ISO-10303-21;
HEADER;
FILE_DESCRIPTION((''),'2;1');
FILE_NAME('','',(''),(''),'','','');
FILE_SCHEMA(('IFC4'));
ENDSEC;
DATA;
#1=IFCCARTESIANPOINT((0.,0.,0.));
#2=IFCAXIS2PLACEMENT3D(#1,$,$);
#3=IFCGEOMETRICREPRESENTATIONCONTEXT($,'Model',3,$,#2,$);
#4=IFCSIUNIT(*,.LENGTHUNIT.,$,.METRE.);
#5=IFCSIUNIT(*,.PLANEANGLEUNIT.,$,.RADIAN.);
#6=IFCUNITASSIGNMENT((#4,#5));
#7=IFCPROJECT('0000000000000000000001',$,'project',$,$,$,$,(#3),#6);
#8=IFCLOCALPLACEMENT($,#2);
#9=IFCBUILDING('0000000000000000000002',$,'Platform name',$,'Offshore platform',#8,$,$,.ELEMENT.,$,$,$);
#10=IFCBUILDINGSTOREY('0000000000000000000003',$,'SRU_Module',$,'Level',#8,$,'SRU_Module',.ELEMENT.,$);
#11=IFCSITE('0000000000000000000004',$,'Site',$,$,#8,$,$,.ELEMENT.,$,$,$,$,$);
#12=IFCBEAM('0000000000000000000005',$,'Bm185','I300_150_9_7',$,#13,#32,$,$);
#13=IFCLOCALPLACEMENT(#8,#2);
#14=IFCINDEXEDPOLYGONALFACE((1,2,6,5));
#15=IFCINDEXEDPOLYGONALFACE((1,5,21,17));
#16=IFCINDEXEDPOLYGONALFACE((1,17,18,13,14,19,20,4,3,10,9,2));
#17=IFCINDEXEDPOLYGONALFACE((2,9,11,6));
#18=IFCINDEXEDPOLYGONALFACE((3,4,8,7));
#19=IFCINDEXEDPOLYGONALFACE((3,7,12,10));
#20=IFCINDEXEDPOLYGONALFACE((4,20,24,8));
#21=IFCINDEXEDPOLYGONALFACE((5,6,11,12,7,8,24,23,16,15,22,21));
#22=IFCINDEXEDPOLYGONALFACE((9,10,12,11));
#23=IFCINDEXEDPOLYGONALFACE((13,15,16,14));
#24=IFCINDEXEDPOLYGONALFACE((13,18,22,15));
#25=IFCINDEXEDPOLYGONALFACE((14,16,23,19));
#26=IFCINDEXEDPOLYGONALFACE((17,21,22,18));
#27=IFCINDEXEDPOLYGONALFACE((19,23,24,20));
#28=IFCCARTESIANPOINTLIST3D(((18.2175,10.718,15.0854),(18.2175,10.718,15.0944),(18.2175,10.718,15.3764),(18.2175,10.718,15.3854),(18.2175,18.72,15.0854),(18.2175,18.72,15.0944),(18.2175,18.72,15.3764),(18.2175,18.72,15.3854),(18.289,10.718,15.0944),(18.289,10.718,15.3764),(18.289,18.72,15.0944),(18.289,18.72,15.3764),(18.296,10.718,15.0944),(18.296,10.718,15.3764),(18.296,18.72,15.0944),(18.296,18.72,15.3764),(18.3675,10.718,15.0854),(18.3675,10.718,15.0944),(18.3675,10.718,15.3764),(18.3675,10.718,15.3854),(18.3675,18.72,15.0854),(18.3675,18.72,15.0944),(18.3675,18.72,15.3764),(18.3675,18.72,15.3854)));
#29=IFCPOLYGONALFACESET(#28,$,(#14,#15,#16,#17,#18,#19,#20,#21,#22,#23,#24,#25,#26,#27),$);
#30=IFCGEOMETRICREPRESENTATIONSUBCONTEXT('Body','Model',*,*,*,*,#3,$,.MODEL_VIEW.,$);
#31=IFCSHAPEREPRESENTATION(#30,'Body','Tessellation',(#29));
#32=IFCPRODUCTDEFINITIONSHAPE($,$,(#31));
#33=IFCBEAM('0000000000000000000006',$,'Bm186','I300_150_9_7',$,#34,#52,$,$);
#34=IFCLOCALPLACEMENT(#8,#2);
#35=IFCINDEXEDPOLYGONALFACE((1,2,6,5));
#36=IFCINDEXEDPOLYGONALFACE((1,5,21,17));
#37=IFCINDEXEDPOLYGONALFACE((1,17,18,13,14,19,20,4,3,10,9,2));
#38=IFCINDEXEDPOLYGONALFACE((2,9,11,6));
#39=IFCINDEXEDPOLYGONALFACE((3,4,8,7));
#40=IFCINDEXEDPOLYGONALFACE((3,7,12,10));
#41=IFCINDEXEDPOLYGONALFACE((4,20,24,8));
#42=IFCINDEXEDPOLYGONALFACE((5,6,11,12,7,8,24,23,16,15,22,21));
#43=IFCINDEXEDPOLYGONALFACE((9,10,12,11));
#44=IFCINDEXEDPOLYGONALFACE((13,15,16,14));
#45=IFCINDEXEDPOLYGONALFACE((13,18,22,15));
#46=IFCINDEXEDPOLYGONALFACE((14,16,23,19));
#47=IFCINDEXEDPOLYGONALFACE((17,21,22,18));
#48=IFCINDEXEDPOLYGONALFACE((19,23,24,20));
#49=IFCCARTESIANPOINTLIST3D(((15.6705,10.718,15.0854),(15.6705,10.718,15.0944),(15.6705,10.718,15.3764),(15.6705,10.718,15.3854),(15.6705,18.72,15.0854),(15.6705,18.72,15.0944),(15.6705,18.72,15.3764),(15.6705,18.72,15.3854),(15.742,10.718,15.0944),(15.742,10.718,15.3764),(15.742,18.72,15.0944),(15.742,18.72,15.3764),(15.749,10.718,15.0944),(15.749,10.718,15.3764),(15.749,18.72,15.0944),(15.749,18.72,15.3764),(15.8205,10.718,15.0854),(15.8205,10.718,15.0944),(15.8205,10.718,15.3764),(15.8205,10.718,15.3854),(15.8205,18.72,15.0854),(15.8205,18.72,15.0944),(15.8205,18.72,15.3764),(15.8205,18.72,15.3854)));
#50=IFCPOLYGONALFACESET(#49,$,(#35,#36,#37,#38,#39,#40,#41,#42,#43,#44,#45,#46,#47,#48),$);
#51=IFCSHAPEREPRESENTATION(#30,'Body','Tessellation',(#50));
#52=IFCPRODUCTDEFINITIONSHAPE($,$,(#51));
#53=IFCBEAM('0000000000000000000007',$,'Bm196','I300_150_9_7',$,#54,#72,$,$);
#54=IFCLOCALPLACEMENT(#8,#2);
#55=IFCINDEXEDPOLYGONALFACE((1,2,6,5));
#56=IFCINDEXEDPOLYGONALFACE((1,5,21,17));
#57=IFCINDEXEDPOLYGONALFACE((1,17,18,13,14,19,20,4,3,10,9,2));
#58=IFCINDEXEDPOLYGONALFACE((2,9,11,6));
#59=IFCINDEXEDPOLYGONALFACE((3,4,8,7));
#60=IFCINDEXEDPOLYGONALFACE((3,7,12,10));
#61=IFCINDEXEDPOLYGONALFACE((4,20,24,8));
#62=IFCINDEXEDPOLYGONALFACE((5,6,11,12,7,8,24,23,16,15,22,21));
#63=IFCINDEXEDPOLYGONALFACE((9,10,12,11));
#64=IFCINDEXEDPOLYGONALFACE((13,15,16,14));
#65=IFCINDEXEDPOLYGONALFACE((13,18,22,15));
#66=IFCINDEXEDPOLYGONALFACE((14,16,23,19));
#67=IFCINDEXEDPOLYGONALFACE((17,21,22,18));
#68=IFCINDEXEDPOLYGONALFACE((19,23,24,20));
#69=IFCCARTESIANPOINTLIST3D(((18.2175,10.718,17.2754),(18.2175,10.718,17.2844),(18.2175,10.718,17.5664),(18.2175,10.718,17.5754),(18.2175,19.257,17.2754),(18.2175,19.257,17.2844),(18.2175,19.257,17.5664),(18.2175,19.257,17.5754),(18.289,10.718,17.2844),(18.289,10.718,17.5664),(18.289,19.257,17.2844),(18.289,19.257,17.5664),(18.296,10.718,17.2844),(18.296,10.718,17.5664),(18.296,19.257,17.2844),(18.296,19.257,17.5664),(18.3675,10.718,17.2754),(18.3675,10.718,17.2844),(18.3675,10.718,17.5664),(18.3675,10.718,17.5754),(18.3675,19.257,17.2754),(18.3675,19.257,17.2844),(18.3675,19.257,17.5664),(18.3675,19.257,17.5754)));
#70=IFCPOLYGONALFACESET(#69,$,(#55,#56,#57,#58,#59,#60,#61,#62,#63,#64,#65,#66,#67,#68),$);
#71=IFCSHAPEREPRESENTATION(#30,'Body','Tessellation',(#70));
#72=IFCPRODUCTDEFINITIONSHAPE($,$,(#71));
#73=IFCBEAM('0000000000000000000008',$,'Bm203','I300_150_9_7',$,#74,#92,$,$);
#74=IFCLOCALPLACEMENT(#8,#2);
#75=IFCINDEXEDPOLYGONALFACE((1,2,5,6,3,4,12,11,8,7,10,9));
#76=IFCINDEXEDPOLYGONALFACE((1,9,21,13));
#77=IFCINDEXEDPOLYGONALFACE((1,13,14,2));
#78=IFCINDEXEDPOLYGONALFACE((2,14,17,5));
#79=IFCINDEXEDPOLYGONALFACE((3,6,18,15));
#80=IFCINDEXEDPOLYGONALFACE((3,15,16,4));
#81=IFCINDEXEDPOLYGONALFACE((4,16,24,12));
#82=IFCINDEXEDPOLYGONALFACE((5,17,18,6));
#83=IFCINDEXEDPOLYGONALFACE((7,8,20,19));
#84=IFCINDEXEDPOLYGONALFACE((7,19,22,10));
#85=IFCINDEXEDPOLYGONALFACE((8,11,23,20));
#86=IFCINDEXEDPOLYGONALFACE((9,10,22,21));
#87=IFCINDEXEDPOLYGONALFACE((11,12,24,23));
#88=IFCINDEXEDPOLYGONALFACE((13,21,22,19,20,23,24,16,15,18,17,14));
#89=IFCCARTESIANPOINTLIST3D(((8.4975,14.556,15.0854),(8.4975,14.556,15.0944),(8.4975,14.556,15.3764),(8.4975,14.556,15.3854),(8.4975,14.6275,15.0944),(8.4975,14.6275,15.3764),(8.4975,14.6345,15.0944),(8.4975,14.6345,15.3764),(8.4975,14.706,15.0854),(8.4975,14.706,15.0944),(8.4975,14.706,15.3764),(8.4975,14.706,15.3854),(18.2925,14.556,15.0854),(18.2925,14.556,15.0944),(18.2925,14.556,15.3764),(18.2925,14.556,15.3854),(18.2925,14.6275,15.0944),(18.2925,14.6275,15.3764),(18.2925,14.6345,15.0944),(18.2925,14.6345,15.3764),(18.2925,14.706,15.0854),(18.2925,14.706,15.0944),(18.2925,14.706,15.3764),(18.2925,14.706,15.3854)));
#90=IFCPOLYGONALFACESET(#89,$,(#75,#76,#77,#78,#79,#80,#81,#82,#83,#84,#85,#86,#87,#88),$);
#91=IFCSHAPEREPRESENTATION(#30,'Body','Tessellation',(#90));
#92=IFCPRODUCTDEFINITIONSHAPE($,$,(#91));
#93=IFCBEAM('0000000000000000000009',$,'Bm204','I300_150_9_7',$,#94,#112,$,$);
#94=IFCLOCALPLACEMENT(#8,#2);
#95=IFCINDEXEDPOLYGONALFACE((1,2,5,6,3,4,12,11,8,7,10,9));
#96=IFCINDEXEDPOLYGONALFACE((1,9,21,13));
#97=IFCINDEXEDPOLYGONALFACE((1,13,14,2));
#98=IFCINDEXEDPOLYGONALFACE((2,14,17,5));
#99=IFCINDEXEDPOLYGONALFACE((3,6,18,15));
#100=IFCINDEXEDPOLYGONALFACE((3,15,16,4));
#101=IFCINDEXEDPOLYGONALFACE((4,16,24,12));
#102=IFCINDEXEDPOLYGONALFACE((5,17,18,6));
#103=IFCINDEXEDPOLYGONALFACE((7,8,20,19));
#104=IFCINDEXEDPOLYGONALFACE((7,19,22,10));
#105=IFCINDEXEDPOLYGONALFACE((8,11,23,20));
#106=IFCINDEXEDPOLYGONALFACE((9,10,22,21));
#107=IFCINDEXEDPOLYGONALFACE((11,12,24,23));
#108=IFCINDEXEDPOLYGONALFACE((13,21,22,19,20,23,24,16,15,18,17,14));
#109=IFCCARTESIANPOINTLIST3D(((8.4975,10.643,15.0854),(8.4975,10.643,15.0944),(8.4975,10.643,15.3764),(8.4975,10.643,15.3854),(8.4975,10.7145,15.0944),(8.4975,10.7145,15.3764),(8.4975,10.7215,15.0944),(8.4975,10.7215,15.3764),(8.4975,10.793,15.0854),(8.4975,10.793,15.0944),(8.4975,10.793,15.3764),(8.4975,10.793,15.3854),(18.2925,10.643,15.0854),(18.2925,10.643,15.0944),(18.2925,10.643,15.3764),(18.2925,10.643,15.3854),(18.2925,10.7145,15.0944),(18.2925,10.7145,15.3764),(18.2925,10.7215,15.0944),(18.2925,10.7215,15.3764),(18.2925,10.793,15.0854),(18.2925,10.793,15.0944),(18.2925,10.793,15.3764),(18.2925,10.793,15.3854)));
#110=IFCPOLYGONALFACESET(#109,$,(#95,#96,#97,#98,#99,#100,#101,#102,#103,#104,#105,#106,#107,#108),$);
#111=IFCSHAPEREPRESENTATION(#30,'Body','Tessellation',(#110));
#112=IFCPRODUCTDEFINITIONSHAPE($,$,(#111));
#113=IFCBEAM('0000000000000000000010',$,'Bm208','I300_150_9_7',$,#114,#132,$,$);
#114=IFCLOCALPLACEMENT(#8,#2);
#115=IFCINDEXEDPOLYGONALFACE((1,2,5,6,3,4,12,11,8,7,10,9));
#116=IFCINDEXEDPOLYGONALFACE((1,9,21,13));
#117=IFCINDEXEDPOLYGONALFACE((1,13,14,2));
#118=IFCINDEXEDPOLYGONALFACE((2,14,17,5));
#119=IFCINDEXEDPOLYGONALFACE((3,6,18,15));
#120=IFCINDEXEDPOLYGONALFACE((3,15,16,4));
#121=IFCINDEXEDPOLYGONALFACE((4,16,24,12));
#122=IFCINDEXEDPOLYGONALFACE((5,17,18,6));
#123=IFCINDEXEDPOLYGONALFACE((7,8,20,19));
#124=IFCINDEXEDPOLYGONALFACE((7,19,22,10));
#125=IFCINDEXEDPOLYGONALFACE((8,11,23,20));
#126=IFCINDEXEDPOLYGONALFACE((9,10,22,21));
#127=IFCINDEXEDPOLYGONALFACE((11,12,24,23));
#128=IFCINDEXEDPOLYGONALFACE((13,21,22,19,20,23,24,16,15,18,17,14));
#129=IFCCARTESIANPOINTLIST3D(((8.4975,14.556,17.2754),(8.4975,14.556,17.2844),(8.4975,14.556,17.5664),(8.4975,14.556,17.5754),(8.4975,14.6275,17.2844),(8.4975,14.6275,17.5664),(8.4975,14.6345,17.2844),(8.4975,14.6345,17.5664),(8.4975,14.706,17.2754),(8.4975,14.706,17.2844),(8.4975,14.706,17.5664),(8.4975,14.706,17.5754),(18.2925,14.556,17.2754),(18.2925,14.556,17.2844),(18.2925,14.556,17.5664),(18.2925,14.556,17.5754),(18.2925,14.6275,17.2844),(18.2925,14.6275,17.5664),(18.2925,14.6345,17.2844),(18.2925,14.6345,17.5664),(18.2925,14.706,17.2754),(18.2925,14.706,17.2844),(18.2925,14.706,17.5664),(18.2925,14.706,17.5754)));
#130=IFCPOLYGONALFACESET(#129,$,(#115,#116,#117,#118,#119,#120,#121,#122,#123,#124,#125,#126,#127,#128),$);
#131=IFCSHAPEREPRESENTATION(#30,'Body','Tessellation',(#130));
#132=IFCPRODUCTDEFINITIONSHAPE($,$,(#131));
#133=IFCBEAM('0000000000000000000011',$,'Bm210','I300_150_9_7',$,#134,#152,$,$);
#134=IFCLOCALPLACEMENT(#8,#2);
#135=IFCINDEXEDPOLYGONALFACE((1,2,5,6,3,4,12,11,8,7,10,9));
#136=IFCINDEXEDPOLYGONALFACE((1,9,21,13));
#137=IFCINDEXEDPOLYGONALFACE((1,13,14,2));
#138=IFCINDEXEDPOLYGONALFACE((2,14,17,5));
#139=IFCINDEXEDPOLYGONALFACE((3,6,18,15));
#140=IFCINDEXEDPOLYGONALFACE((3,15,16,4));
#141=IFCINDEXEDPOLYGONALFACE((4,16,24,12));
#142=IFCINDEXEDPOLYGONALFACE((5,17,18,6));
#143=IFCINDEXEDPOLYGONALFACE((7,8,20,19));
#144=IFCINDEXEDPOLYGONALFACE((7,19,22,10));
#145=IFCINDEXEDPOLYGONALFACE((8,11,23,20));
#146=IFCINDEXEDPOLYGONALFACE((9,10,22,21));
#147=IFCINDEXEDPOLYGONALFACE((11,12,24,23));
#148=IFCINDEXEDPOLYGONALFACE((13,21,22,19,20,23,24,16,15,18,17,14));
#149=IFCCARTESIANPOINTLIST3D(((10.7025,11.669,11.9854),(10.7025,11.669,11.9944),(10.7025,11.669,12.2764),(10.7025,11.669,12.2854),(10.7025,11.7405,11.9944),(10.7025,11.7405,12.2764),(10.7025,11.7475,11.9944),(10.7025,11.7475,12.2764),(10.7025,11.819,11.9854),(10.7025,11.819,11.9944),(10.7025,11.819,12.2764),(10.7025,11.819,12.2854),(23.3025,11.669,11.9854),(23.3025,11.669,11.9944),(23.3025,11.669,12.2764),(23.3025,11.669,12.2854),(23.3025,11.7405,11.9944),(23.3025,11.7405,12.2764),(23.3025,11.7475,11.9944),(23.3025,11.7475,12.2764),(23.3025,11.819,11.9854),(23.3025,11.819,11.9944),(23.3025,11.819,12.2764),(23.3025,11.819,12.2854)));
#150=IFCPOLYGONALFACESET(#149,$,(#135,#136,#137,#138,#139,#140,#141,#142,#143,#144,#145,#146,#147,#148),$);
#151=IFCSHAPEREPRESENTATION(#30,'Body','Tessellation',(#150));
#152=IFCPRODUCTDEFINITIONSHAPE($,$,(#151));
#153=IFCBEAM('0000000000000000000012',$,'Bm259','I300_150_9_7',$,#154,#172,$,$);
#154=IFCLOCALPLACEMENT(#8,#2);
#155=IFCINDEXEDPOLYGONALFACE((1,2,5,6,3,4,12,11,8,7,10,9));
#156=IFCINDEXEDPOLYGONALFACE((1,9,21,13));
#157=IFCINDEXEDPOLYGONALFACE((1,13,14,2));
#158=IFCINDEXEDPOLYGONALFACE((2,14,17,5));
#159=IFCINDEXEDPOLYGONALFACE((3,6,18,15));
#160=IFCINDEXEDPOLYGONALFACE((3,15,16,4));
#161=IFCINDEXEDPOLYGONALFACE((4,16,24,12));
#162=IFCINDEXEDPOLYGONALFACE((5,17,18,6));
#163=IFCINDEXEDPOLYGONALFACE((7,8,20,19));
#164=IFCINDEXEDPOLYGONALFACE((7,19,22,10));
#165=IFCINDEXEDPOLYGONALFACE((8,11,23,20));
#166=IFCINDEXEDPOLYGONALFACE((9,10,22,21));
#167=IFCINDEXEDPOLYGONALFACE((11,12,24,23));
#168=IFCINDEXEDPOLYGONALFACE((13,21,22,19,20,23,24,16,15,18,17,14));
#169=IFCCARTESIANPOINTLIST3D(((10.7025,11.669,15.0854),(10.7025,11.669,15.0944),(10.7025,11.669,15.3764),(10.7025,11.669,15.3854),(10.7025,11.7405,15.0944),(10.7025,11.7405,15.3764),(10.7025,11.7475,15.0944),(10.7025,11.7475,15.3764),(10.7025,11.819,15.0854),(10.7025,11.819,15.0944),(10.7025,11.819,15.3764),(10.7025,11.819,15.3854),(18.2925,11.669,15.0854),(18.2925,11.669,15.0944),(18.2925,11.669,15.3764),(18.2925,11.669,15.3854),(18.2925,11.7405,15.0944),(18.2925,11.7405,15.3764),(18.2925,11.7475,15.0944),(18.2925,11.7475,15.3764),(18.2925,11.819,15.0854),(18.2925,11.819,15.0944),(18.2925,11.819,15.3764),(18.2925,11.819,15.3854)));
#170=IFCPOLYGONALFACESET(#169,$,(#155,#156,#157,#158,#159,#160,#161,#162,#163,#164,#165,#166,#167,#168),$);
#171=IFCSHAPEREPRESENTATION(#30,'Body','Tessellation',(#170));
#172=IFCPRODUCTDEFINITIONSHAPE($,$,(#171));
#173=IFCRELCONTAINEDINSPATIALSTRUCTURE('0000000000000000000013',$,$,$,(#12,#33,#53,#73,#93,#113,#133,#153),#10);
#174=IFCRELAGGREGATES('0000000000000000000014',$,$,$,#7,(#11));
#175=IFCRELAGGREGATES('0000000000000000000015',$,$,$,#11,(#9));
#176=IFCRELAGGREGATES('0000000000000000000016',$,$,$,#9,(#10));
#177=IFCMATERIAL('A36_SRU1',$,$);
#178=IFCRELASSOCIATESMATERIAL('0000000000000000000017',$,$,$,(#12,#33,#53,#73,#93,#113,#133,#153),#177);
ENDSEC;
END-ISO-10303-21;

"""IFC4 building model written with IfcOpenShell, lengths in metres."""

from ifc_helpers import new_model, si_unit, frame, origin, origin_2d, place, context, subcontext, project, spatial, i_section, extrude, source, transform, mapped, material, element, save


model = new_model("IFC4")

# Units and contexts
model_context = context("Model", 3, world=origin())
body_context = subcontext(model_context, "Body", "Model", "MODEL_VIEW")
ifc_project = project(units=[si_unit("LENGTHUNIT", "METRE"), si_unit("PLANEANGLEUNIT", "RADIAN")], contexts=[model_context])

# Site, building, storey
placement_1 = place(None, origin())
site = spatial("IfcSite", under=ifc_project, at=placement_1, Name="Site", CompositionType="ELEMENT")
building = spatial("IfcBuilding", under=site, at=placement_1, Name="Platform name", ObjectType="Offshore platform", CompositionType="ELEMENT")
storey = spatial("IfcBuildingStorey", under=building, at=placement_1, Name="SRU_Module", ObjectType="Level", LongName="SRU_Module", CompositionType="ELEMENT")

# Beams
ifc_material = material(Name="A36_SRU1")
shared_shape_1 = source(origin(), body_context, "Body", "SweptSolid", [
    extrude(i_section(OverallWidth=0.15, OverallDepth=0.3, WebThickness=0.007, FlangeThickness=0.009, FilletRadius=0.0, at=origin_2d()), frame((0.0, 0.0, 0.0), z_axis=(0.0, 1.0, 0.0), x_axis=(-1.0, 0.0, 0.0)), (0.0, 0.0, 1.0), 8.002),
])
placement_2 = place(None, origin())
placement_3 = place(placement_2, origin())
placement_4 = place(placement_3, origin())
beam_1_placement = place(placement_4, frame((18.2925, 10.718, 15.2354)))
element("IfcBeam", 1, at=beam_1_placement, inside=storey, material=ifc_material, Name="Bm185", Description="I300_150_9_7", context=body_context, shape_type="MappedRepresentation", body=[
    mapped(shared_shape_1, transform((0.0, 0.0, 0.0), scale=1.0)),
])
shared_shape_2 = source(origin(), body_context, "Body", "SweptSolid", [
    extrude(i_section(OverallWidth=0.15, OverallDepth=0.3, WebThickness=0.007, FlangeThickness=0.009, FilletRadius=0.0, at=origin_2d()), frame((0.0, 0.0, 0.0), z_axis=(0.0, 1.0, 0.0), x_axis=(-1.0, 0.0, 0.0)), (0.0, 0.0, 1.0), 8.002),
])
placement_5 = place(None, origin())
placement_6 = place(placement_5, origin())
placement_7 = place(placement_6, origin())
beam_2_placement = place(placement_7, frame((15.7455, 10.718, 15.2354)))
element("IfcBeam", 2, at=beam_2_placement, inside=storey, material=ifc_material, Name="Bm186", Description="I300_150_9_7", context=body_context, shape_type="MappedRepresentation", body=[
    mapped(shared_shape_2, transform((0.0, 0.0, 0.0), scale=1.0)),
])
shared_shape_3 = source(origin(), body_context, "Body", "SweptSolid", [
    extrude(i_section(OverallWidth=0.15, OverallDepth=0.3, WebThickness=0.007, FlangeThickness=0.009, FilletRadius=0.0, at=origin_2d()), frame((0.0, 0.0, 0.0), z_axis=(0.0, 1.0, 0.0), x_axis=(-1.0, 0.0, 0.0)), (0.0, 0.0, 1.0), 8.539),
])
placement_8 = place(None, origin())
placement_9 = place(placement_8, origin())
placement_10 = place(placement_9, origin())
beam_3_placement = place(placement_10, frame((18.2925, 10.718, 17.4254)))
element("IfcBeam", 3, at=beam_3_placement, inside=storey, material=ifc_material, Name="Bm196", Description="I300_150_9_7", context=body_context, shape_type="MappedRepresentation", body=[
    mapped(shared_shape_3, transform((0.0, 0.0, 0.0), scale=1.0)),
])
shared_shape_4 = source(origin(), body_context, "Body", "SweptSolid", [
    extrude(i_section(OverallWidth=0.15, OverallDepth=0.3, WebThickness=0.007, FlangeThickness=0.009, FilletRadius=0.0, at=origin_2d()), frame((0.0, 0.0, 0.0), z_axis=(-1.0, 0.0, 0.0), x_axis=(0.0, -1.0, 0.0)), (0.0, 0.0, 1.0), 9.795),
])
placement_11 = place(None, origin())
placement_12 = place(placement_11, origin())
placement_13 = place(placement_12, origin())
beam_4_placement = place(placement_13, frame((18.2925, 14.631, 15.2354)))
element("IfcBeam", 4, at=beam_4_placement, inside=storey, material=ifc_material, Name="Bm203", Description="I300_150_9_7", context=body_context, shape_type="MappedRepresentation", body=[
    mapped(shared_shape_4, transform((0.0, 0.0, 0.0), scale=1.0)),
])
shared_shape_5 = source(origin(), body_context, "Body", "SweptSolid", [
    extrude(i_section(OverallWidth=0.15, OverallDepth=0.3, WebThickness=0.007, FlangeThickness=0.009, FilletRadius=0.0, at=origin_2d()), frame((0.0, 0.0, 0.0), z_axis=(-1.0, 0.0, 0.0), x_axis=(0.0, -1.0, 0.0)), (0.0, 0.0, 1.0), 9.795),
])
placement_14 = place(None, origin())
placement_15 = place(placement_14, origin())
placement_16 = place(placement_15, origin())
beam_5_placement = place(placement_16, frame((18.2925, 10.718, 15.2354)))
element("IfcBeam", 5, at=beam_5_placement, inside=storey, material=ifc_material, Name="Bm204", Description="I300_150_9_7", context=body_context, shape_type="MappedRepresentation", body=[
    mapped(shared_shape_5, transform((0.0, 0.0, 0.0), scale=1.0)),
])
shared_shape_6 = source(origin(), body_context, "Body", "SweptSolid", [
    extrude(i_section(OverallWidth=0.15, OverallDepth=0.3, WebThickness=0.007, FlangeThickness=0.009, FilletRadius=0.0, at=origin_2d()), frame((0.0, 0.0, 0.0), z_axis=(-1.0, 0.0, 0.0), x_axis=(0.0, -1.0, 0.0)), (0.0, 0.0, 1.0), 9.795),
])
placement_17 = place(None, origin())
placement_18 = place(placement_17, origin())
placement_19 = place(placement_18, origin())
beam_6_placement = place(placement_19, frame((18.2925, 14.631, 17.4254)))
element("IfcBeam", 6, at=beam_6_placement, inside=storey, material=ifc_material, Name="Bm208", Description="I300_150_9_7", context=body_context, shape_type="MappedRepresentation", body=[
    mapped(shared_shape_6, transform((0.0, 0.0, 0.0), scale=1.0)),
])
shared_shape_7 = source(origin(), body_context, "Body", "SweptSolid", [
    extrude(i_section(OverallWidth=0.15, OverallDepth=0.3, WebThickness=0.007, FlangeThickness=0.009, FilletRadius=0.0, at=origin_2d()), frame((0.0, 0.0, 0.0), z_axis=(-1.0, 0.0, 0.0), x_axis=(0.0, -1.0, 0.0)), (0.0, 0.0, 1.0), 12.6),
])
placement_20 = place(None, origin())
placement_21 = place(placement_20, origin())
placement_22 = place(placement_21, origin())
beam_7_placement = place(placement_22, frame((23.3025, 11.744, 12.1354)))
element("IfcBeam", 7, at=beam_7_placement, inside=storey, material=ifc_material, Name="Bm210", Description="I300_150_9_7", context=body_context, shape_type="MappedRepresentation", body=[
    mapped(shared_shape_7, transform((0.0, 0.0, 0.0), scale=1.0)),
])
shared_shape_8 = source(origin(), body_context, "Body", "SweptSolid", [
    extrude(i_section(OverallWidth=0.15, OverallDepth=0.3, WebThickness=0.007, FlangeThickness=0.009, FilletRadius=0.0, at=origin_2d()), frame((0.0, 0.0, 0.0), z_axis=(-1.0, 0.0, 0.0), x_axis=(0.0, -1.0, 0.0)), (0.0, 0.0, 1.0), 7.59),
])
placement_23 = place(None, origin())
placement_24 = place(placement_23, origin())
placement_25 = place(placement_24, origin())
beam_8_placement = place(placement_25, frame((18.2925, 11.744, 15.2354)))
element("IfcBeam", 8, at=beam_8_placement, inside=storey, material=ifc_material, Name="Bm259", Description="I300_150_9_7", context=body_context, shape_type="MappedRepresentation", body=[
    mapped(shared_shape_8, transform((0.0, 0.0, 0.0), scale=1.0)),
])

save(model, "model.ifc")
